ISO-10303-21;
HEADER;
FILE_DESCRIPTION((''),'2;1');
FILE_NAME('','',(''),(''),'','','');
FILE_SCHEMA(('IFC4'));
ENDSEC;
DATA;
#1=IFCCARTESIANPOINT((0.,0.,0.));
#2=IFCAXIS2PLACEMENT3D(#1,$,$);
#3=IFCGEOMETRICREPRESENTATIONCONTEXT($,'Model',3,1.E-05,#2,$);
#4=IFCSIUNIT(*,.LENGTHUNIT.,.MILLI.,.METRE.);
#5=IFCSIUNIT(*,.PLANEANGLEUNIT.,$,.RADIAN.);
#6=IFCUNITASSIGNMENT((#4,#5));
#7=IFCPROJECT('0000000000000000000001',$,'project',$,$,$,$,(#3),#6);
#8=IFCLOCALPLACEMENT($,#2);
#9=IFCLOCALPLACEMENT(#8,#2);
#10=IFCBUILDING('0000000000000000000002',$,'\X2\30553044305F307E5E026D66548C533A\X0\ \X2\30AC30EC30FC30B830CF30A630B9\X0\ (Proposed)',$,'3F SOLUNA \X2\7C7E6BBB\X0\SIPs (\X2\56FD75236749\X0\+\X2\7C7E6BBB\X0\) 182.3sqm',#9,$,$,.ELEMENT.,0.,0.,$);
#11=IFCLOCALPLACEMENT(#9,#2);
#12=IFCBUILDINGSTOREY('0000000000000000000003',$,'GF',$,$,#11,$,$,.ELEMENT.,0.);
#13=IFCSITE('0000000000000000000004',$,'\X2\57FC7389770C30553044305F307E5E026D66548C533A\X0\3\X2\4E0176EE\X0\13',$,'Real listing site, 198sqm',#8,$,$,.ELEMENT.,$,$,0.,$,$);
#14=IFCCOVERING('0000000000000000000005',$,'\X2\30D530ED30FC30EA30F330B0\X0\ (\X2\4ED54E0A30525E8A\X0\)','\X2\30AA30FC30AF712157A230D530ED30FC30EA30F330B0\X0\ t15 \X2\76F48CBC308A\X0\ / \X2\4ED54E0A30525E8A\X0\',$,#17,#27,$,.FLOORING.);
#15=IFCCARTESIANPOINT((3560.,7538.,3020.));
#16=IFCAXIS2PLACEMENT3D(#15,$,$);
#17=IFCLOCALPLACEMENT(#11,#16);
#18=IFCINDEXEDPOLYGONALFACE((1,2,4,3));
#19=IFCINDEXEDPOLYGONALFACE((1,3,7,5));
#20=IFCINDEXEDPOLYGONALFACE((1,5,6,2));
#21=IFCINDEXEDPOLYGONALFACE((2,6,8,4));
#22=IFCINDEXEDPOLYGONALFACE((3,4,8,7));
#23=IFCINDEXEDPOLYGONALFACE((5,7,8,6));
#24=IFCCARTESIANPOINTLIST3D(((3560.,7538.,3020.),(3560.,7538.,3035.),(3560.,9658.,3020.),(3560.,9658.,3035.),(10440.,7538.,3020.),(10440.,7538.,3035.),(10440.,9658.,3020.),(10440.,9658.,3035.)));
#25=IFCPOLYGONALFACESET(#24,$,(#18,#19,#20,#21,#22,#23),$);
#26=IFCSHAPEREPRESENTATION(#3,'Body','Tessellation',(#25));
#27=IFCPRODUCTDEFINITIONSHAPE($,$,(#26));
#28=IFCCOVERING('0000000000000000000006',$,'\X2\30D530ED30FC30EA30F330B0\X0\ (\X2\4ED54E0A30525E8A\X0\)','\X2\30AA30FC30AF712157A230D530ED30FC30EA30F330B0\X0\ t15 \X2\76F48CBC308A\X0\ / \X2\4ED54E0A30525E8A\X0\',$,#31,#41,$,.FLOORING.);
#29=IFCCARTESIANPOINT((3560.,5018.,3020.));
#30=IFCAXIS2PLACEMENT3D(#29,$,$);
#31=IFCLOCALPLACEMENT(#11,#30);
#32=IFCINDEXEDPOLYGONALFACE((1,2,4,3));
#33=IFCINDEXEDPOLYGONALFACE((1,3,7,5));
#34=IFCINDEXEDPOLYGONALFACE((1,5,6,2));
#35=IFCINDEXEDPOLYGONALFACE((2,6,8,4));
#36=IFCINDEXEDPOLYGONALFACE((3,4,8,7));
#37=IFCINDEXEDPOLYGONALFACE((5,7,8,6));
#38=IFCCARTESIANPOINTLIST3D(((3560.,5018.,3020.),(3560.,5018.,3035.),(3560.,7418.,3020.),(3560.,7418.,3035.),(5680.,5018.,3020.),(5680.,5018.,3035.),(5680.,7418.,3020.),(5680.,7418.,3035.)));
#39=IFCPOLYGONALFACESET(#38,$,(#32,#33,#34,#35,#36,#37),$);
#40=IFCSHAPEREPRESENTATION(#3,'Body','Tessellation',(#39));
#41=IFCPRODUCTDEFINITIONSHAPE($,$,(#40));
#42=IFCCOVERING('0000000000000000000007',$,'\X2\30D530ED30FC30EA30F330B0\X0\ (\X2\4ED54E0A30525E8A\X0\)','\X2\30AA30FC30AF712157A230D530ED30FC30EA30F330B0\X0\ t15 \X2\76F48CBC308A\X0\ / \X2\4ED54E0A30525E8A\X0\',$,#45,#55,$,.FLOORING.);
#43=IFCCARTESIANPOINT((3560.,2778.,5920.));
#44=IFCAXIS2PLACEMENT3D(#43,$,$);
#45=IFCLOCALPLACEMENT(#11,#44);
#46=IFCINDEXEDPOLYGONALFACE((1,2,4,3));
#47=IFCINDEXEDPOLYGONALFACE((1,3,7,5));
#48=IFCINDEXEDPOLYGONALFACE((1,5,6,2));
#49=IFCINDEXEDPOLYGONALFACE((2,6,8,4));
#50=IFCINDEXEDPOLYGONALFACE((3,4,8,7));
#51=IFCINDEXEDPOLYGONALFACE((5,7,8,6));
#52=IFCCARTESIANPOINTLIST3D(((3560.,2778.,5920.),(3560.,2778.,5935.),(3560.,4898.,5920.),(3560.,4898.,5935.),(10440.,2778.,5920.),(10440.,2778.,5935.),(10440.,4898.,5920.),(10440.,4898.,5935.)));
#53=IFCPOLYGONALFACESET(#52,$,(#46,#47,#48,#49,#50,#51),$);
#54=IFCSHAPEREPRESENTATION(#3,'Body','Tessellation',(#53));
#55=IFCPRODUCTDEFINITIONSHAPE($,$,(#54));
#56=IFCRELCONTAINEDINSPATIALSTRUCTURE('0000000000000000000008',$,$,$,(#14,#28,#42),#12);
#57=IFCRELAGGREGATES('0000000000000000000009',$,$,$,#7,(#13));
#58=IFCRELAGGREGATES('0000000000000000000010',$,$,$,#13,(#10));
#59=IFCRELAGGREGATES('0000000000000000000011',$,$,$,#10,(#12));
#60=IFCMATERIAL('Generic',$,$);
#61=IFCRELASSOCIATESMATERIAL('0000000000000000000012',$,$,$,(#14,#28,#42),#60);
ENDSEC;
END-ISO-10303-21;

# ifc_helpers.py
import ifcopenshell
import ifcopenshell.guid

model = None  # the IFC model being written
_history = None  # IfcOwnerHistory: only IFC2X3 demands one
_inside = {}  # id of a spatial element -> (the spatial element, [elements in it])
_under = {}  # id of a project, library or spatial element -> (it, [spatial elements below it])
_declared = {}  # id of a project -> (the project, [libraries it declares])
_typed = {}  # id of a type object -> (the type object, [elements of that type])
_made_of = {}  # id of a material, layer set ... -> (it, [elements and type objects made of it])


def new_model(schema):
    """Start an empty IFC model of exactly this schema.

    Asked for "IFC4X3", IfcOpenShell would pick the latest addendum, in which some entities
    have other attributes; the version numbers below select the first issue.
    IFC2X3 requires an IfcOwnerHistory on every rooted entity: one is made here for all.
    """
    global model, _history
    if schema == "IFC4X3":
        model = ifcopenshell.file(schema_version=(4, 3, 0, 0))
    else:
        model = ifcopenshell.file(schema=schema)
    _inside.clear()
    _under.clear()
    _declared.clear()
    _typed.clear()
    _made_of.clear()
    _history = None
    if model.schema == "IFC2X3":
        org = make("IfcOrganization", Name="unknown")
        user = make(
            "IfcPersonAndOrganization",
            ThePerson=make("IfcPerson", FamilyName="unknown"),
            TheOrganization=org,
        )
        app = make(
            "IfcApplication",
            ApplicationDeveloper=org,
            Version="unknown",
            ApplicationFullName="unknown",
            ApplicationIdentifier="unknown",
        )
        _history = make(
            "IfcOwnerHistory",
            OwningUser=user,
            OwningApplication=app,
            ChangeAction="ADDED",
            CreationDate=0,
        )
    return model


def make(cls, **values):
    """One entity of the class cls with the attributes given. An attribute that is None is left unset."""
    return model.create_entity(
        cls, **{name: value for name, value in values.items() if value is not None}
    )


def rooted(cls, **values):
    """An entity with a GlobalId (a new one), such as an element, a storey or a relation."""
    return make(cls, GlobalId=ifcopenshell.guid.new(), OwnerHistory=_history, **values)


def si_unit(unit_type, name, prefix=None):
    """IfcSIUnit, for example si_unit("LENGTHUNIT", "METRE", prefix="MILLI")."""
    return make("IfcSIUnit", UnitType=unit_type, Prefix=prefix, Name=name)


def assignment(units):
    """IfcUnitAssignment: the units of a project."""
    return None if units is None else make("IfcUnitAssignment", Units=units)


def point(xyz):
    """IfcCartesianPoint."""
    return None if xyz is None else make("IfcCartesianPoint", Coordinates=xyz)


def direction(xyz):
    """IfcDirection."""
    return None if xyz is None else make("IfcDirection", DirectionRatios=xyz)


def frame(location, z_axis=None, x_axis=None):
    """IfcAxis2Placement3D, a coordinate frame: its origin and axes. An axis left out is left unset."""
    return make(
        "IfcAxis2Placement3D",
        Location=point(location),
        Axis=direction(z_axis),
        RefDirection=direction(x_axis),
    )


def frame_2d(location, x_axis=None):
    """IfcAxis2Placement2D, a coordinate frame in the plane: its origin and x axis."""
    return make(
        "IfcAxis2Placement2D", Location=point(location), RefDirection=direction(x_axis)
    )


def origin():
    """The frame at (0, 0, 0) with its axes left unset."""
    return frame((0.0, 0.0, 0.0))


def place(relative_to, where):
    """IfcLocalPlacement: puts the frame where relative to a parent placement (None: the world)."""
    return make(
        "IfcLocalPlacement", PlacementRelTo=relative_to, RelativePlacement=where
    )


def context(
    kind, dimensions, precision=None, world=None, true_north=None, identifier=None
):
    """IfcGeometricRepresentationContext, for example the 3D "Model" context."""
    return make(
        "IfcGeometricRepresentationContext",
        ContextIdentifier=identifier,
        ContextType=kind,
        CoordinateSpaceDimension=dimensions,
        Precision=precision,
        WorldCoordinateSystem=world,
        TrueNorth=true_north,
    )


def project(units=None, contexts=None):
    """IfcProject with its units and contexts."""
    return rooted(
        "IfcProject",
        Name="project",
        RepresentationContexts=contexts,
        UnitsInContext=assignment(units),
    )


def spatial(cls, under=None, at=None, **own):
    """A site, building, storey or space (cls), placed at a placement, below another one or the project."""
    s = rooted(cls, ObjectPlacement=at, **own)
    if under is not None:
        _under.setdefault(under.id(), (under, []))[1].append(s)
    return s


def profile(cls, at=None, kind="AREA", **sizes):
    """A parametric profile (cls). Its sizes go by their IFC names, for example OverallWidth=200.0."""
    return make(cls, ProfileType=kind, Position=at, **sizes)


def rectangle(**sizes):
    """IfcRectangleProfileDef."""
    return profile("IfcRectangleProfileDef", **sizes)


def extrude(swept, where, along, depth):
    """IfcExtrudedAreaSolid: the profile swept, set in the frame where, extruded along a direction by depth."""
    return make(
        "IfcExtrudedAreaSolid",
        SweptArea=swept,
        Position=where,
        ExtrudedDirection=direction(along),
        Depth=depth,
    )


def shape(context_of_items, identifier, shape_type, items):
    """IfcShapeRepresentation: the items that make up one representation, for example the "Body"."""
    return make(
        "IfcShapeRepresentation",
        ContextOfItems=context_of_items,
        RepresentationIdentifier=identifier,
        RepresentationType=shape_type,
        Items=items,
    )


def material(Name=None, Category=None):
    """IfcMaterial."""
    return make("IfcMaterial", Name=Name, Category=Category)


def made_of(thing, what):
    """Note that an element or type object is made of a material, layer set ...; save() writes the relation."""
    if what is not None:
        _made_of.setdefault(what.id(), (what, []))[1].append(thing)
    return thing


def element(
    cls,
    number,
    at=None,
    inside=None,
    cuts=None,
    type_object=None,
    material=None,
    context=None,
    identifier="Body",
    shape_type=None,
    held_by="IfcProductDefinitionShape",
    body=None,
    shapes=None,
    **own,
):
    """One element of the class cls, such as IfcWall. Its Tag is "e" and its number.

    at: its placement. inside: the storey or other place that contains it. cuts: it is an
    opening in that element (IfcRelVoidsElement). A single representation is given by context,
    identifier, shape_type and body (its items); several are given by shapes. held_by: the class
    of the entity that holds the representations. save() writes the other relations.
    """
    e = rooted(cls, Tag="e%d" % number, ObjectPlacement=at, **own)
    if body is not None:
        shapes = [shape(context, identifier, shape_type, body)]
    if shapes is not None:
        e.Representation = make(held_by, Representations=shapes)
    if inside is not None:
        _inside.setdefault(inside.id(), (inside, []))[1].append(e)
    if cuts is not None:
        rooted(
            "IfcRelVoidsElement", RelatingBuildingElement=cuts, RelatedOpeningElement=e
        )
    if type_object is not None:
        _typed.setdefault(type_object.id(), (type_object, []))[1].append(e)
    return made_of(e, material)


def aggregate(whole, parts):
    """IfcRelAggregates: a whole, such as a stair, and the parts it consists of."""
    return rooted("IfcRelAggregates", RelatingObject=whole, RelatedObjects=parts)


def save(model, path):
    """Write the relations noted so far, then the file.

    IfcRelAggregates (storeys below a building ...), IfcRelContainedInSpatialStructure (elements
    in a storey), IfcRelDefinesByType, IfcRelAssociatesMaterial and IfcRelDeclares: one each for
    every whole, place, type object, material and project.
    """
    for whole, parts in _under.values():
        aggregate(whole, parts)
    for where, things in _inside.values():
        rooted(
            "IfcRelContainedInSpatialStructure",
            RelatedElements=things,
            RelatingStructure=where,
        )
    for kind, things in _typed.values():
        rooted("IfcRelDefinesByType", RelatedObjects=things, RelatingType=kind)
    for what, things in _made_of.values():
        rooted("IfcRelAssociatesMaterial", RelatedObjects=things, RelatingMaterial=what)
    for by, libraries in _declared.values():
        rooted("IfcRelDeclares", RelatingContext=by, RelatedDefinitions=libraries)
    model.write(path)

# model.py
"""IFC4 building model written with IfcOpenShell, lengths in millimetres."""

from ifc_helpers import new_model, si_unit, frame, frame_2d, origin, place, context, project, spatial, rectangle, extrude, material, element, save


model = new_model("IFC4")

# Units and contexts
model_context = context("Model", 3, precision=1e-05, world=origin())
ifc_project = project(units=[si_unit("LENGTHUNIT", "METRE", prefix="MILLI"), si_unit("PLANEANGLEUNIT", "RADIAN")], contexts=[model_context])

# Site, building, storey
site_placement = place(None, origin())
site = spatial("IfcSite", under=ifc_project, at=site_placement, Name="埼玉県さいたま市浦和区3丁目13", ObjectType="Real listing site, 198sqm", CompositionType="ELEMENT", RefElevation=0.0)
building_placement = place(site_placement, origin())
building = spatial("IfcBuilding", under=site, at=building_placement, Name="さいたま市浦和区 ガレージハウス (Proposed)", ObjectType="3F SOLUNA 籾殻SIPs (国産杉+籾殻) 182.3sqm", CompositionType="ELEMENT", ElevationOfRefHeight=0.0, ElevationOfTerrain=0.0)
storey_placement = place(building_placement, origin())
storey = spatial("IfcBuildingStorey", under=building, at=storey_placement, Name="GF", CompositionType="ELEMENT", Elevation=0.0)

# Shared definitions
ifc_material_1 = material(Name="Generic")

# Coverings
covering_1_placement = place(storey_placement, frame((3560.0, 7538.0, 3020.0)))
element("IfcCovering", 1, at=covering_1_placement, inside=storey, material=ifc_material_1, Name="フローリング (仕上げ床)", Description="オーク無垢フローリング t15 直貼り / 仕上げ床", PredefinedType="FLOORING", context=model_context, shape_type="SweptSolid", body=[
    extrude(rectangle(XDim=6880.0, YDim=2120.0, at=frame_2d((3440.0, 1060.0))), frame((3560.0, 7538.0, 3020.0)), (0.0, 0.0, 1.0), 15.0),
])
covering_2_placement = place(storey_placement, frame((3560.0, 5018.0, 3020.0)))
element("IfcCovering", 2, at=covering_2_placement, inside=storey, material=ifc_material_1, Name="フローリング (仕上げ床)", Description="オーク無垢フローリング t15 直貼り / 仕上げ床", PredefinedType="FLOORING", context=model_context, shape_type="SweptSolid", body=[
    extrude(rectangle(XDim=2120.0, YDim=2400.0, at=frame_2d((1060.0, 1200.0))), frame((3560.0, 5018.0, 3020.0)), (0.0, 0.0, 1.0), 15.0),
])
covering_3_placement = place(storey_placement, frame((3560.0, 2778.0, 5920.0)))
element("IfcCovering", 3, at=covering_3_placement, inside=storey, material=ifc_material_1, Name="フローリング (仕上げ床)", Description="オーク無垢フローリング t15 直貼り / 仕上げ床", PredefinedType="FLOORING", context=model_context, shape_type="SweptSolid", body=[
    extrude(rectangle(XDim=6880.0, YDim=2120.0, at=frame_2d((3440.0, 1060.0))), frame((3560.0, 2778.0, 5920.0)), (0.0, 0.0, 1.0), 15.0),
])

save(model, "model.ifc")
